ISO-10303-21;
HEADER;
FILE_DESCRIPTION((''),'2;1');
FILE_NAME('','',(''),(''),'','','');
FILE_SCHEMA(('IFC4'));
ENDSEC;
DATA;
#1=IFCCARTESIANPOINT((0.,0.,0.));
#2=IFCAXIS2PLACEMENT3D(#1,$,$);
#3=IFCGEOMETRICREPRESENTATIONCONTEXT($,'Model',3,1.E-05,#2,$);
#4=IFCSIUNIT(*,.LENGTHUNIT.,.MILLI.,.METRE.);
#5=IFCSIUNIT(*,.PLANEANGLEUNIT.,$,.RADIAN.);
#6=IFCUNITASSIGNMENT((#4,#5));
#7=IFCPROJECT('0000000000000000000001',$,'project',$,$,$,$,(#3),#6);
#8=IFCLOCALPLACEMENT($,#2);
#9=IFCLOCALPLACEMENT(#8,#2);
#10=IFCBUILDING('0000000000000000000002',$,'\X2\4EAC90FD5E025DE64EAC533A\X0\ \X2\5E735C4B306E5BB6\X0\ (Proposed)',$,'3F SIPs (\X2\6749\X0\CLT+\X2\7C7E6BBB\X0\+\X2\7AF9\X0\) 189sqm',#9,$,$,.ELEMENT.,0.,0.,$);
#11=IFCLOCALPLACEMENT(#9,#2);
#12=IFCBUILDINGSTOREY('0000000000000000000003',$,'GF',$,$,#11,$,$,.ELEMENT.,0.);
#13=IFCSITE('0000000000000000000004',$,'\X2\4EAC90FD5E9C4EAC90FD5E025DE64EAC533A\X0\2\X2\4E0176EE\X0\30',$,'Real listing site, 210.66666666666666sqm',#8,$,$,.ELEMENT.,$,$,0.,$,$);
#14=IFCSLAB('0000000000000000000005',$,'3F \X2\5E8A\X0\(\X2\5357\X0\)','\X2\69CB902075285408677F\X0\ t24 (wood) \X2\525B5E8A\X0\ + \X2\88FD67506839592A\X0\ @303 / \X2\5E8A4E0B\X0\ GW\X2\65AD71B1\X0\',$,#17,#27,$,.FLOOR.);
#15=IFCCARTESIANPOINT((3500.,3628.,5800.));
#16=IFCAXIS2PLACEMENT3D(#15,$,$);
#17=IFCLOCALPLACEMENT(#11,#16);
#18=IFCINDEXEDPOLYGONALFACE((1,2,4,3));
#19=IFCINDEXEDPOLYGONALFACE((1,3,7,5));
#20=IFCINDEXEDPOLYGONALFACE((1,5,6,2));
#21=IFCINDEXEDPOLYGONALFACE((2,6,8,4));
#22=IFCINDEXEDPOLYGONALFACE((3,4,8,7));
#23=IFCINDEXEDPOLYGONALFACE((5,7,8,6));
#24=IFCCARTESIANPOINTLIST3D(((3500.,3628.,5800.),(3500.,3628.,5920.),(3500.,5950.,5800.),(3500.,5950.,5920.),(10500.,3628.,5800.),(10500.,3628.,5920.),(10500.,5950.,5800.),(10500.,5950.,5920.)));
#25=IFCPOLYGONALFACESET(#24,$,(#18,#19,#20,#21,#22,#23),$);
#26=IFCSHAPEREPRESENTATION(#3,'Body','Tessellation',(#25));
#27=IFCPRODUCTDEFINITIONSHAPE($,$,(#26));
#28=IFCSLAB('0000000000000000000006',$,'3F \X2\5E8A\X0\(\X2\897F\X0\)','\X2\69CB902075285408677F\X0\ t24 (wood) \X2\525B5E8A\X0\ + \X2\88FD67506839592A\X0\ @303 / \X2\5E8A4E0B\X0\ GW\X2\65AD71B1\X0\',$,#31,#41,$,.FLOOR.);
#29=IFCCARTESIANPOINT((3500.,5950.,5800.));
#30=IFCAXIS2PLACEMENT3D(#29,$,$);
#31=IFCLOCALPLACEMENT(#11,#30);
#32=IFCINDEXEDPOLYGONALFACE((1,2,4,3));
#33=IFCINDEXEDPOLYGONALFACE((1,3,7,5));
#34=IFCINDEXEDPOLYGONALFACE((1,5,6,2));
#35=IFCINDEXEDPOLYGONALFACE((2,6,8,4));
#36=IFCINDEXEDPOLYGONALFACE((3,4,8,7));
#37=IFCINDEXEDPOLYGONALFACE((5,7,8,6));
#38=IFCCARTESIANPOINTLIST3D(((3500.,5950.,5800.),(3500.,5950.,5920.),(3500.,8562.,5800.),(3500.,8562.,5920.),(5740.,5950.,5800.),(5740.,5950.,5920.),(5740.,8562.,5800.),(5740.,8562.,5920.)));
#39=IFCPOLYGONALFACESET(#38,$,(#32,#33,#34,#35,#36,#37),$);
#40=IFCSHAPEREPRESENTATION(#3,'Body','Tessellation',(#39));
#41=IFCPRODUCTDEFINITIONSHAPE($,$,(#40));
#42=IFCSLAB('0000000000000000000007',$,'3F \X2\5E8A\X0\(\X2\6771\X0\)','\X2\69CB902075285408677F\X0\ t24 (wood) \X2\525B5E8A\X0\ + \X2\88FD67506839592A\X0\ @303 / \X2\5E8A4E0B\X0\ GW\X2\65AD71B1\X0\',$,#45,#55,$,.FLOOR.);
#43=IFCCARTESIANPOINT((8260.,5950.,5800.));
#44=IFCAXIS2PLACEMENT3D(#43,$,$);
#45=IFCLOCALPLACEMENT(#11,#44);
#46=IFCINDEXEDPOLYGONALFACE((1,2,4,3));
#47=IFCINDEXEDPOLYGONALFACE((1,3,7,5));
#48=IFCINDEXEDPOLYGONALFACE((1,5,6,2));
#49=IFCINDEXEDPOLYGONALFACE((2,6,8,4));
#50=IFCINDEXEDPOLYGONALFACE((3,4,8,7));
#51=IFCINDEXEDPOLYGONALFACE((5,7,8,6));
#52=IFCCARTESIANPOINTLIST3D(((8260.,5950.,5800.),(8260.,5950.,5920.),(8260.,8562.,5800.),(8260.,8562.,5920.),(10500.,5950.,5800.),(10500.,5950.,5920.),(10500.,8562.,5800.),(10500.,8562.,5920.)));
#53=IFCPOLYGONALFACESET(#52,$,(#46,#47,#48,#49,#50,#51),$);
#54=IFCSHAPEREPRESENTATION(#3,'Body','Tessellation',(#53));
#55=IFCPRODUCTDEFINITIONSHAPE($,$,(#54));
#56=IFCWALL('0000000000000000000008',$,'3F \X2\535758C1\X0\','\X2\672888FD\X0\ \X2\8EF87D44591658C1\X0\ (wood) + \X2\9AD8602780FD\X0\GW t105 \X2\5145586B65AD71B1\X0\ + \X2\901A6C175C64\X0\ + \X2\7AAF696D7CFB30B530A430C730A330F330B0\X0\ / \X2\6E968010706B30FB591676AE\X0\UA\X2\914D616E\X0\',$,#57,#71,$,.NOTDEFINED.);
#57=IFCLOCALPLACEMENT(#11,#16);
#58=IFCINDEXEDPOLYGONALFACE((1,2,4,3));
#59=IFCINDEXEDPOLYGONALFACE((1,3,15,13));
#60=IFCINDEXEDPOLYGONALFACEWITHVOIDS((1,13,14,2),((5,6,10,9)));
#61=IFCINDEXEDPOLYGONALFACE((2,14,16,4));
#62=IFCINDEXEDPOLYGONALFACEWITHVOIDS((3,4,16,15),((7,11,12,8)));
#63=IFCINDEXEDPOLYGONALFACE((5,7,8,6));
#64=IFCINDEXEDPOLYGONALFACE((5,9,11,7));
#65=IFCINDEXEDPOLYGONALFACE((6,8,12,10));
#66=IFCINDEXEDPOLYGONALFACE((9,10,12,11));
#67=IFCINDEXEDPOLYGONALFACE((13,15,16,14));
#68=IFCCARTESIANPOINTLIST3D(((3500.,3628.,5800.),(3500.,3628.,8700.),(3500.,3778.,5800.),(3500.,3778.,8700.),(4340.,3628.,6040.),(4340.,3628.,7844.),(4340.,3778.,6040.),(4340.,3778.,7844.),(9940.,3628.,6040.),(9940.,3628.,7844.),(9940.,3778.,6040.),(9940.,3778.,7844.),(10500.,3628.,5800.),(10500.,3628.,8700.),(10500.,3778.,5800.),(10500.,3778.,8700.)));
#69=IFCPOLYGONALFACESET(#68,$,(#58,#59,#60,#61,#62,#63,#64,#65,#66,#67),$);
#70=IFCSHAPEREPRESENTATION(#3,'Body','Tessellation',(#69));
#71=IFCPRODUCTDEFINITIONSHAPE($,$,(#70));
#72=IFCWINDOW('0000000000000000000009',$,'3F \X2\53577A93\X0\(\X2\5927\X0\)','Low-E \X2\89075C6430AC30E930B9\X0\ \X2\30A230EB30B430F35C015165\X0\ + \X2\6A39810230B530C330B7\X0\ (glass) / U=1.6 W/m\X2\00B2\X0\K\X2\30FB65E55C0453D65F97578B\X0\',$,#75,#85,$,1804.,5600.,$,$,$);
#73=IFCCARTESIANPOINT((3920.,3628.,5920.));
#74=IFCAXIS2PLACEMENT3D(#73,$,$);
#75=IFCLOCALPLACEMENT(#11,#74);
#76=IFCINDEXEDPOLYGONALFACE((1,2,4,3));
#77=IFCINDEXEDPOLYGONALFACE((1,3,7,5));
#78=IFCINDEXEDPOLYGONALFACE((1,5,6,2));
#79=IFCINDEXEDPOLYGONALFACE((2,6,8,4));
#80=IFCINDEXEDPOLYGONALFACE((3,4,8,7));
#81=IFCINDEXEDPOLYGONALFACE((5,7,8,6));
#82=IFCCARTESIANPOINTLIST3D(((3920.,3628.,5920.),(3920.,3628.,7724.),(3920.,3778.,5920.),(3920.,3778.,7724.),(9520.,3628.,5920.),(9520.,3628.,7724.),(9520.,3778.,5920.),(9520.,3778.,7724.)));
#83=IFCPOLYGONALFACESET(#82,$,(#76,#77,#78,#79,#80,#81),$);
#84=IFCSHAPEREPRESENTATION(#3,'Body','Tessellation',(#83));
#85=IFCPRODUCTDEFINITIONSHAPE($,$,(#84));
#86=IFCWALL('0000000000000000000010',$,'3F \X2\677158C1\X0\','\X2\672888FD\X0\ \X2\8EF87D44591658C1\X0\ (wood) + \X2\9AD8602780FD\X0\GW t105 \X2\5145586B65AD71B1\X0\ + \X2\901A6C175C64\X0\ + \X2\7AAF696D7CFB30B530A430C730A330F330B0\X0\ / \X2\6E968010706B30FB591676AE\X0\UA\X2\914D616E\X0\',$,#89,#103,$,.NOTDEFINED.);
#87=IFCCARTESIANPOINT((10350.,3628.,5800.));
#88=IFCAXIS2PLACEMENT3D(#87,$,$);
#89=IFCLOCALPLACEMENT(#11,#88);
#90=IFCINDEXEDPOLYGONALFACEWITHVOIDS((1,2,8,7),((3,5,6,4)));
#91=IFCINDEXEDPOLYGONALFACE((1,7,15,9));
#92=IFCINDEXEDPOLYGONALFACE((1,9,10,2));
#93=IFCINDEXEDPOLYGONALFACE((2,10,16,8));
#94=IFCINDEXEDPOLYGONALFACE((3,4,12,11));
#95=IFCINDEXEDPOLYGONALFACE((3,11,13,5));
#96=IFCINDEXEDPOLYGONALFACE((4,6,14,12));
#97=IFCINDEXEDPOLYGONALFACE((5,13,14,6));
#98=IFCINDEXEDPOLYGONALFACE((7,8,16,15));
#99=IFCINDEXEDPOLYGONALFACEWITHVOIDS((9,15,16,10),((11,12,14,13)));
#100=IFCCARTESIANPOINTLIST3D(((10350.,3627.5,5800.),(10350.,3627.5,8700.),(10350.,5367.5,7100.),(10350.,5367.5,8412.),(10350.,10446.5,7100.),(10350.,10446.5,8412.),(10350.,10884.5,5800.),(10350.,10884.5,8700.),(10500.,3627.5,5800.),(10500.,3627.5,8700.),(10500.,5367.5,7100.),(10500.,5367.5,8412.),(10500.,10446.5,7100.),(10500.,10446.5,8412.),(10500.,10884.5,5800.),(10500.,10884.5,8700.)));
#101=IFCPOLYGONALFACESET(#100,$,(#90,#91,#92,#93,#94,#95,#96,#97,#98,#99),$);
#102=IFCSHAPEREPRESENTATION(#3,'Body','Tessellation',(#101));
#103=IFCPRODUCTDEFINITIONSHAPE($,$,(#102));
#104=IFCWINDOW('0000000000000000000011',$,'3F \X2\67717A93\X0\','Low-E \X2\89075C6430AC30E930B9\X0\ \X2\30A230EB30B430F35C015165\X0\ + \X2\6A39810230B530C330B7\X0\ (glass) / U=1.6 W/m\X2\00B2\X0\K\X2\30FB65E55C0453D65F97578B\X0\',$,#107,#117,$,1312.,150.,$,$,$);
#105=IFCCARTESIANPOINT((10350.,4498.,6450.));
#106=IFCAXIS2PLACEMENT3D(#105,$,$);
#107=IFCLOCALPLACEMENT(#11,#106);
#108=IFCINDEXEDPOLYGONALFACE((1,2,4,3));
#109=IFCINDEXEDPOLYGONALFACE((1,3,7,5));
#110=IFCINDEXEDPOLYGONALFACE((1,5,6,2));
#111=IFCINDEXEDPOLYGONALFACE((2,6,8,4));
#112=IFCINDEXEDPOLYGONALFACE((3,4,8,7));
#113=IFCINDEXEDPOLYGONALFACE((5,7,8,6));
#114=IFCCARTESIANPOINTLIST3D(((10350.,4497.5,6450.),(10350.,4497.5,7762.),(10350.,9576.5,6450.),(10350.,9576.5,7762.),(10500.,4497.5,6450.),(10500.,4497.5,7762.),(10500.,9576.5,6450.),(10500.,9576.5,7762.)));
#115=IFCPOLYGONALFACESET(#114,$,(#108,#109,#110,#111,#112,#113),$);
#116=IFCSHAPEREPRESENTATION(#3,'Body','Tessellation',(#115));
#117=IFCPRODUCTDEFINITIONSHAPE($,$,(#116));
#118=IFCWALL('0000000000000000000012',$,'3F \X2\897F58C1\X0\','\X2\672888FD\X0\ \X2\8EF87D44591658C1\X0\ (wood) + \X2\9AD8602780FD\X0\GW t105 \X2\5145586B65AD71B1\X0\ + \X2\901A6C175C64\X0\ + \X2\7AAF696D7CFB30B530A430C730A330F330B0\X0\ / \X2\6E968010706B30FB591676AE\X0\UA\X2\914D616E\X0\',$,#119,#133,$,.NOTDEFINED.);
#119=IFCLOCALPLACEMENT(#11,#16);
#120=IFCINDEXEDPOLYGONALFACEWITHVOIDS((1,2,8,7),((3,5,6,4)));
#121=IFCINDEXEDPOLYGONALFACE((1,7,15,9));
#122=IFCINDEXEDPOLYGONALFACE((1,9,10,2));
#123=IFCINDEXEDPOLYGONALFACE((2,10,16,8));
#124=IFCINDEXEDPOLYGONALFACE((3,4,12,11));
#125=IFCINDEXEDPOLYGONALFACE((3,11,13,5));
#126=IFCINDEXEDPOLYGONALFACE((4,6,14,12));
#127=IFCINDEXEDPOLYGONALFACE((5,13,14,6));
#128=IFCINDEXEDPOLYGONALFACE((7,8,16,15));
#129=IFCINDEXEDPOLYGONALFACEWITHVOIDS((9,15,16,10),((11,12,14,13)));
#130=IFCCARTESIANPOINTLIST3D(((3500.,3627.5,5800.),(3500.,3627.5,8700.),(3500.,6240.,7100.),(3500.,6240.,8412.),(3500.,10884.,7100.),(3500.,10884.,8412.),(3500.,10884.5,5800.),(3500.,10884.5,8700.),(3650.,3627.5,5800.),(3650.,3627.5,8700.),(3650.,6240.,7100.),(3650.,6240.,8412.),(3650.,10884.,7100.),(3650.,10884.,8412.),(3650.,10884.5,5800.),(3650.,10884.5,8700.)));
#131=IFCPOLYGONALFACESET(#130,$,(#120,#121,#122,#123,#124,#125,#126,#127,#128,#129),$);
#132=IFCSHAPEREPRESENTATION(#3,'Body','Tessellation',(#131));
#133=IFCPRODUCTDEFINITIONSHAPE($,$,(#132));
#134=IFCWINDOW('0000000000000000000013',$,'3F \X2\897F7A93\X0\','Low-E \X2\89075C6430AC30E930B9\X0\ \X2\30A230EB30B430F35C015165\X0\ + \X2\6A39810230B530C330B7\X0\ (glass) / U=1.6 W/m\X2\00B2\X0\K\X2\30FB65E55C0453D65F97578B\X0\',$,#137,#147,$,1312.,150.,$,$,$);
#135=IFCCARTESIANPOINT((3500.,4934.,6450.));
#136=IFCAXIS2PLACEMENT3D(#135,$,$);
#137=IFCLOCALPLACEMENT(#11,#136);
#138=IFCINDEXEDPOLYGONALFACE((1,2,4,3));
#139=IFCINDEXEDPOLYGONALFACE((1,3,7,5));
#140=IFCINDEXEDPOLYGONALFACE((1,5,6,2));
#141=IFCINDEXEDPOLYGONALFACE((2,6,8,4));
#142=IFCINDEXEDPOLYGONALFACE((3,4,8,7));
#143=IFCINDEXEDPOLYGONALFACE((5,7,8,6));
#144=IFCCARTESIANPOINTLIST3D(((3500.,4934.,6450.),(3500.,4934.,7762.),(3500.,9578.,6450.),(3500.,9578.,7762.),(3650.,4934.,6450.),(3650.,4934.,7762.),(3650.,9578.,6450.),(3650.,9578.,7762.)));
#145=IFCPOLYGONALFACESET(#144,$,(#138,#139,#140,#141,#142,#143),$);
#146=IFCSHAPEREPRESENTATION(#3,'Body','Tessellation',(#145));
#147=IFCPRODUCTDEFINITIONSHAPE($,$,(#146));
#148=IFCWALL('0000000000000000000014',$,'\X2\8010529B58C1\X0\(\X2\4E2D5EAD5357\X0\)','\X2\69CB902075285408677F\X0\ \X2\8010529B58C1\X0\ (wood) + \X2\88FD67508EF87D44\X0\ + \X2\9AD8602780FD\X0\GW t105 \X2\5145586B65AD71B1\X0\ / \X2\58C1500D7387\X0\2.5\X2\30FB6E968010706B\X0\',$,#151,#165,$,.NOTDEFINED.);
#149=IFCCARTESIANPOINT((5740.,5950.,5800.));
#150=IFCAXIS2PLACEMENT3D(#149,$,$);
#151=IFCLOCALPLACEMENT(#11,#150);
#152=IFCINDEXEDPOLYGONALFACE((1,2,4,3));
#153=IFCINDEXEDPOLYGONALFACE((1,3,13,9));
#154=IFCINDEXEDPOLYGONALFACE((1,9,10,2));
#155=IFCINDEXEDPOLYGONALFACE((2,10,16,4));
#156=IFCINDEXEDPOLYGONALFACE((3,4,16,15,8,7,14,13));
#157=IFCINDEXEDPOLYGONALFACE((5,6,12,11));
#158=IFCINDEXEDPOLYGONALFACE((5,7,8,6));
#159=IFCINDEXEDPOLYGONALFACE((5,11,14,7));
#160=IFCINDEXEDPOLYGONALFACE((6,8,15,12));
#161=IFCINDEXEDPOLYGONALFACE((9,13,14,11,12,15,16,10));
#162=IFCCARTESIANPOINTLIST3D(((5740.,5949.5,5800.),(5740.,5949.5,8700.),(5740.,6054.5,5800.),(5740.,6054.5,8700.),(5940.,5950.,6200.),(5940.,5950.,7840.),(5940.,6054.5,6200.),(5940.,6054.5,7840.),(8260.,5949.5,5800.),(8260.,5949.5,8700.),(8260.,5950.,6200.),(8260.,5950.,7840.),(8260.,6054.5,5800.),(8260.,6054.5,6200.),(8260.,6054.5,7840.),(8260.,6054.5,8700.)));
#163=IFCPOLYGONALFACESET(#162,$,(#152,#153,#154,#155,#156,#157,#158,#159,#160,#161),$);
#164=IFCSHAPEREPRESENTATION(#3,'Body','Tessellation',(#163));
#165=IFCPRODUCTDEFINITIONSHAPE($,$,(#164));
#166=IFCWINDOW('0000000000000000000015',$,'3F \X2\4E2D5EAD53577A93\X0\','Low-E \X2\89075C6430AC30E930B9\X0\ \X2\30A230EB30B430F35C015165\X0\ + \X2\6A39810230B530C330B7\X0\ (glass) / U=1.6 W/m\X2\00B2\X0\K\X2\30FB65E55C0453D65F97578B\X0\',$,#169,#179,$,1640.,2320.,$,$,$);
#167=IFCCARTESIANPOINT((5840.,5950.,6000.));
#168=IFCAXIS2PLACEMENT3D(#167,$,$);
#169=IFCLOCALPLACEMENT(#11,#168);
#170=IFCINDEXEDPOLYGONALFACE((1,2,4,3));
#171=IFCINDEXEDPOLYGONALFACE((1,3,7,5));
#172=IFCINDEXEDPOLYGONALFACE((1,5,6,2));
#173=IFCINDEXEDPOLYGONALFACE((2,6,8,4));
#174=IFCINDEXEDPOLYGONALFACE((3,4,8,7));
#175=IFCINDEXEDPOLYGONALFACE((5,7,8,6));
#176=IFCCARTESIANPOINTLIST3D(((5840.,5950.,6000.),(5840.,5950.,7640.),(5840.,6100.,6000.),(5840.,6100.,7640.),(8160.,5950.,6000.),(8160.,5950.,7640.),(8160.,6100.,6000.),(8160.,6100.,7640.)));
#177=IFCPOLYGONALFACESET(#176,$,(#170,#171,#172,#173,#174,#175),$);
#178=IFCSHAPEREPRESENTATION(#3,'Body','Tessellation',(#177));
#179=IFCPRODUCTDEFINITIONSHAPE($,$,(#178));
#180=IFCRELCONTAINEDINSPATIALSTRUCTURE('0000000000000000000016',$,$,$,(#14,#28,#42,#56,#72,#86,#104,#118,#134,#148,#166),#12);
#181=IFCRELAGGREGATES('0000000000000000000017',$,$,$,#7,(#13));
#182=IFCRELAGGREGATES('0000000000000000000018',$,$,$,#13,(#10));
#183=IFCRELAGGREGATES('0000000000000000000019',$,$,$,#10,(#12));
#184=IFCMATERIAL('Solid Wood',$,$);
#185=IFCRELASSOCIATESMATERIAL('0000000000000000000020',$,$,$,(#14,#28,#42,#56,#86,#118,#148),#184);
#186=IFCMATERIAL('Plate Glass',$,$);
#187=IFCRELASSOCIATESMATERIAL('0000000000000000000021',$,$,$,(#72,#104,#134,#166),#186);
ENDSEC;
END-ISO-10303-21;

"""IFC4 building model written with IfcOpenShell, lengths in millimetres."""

from ifc_helpers import new_model, si_unit, frame, frame_2d, origin, place, context, project, spatial, rectangle, extrude, material, element, fill, save


model = new_model("IFC4")

# Units and contexts
model_context = context("Model", 3, precision=1e-05, world=origin())
ifc_project = project(units=[si_unit("LENGTHUNIT", "METRE", prefix="MILLI"), si_unit("PLANEANGLEUNIT", "RADIAN")], contexts=[model_context])

# Site, building, storey
site_placement = place(None, origin())
site = spatial("IfcSite", under=ifc_project, at=site_placement, Name="京都府京都市左京区2丁目30", ObjectType="Real listing site, 210.66666666666666sqm", CompositionType="ELEMENT", RefElevation=0.0)
building_placement = place(site_placement, origin())
building = spatial("IfcBuilding", under=site, at=building_placement, Name="京都市左京区 平屋の家 (Proposed)", ObjectType="3F SIPs (杉CLT+籾殻+竹) 189sqm", CompositionType="ELEMENT", ElevationOfRefHeight=0.0, ElevationOfTerrain=0.0)
storey_placement = place(building_placement, origin())
storey = spatial("IfcBuildingStorey", under=building, at=storey_placement, Name="GF", CompositionType="ELEMENT", Elevation=0.0)

# Slabs
ifc_material_1 = material(Name="Solid Wood")
slab_1_placement = place(storey_placement, frame((3500.0, 3628.0, 5800.0)))
element("IfcSlab", 1, at=slab_1_placement, inside=storey, material=ifc_material_1, Name="3F 床(南)", Description="構造用合板 t24 (wood) 剛床 + 製材根太 @303 / 床下 GW断熱", PredefinedType="FLOOR", context=model_context, shape_type="SweptSolid", body=[
    extrude(rectangle(XDim=7000.0, YDim=2322.0, at=frame_2d((3500.0, 1161.0))), frame((3500.0, 3628.0, 5800.0)), (0.0, 0.0, 1.0), 120.0),
])
slab_2_placement = place(storey_placement, frame((3500.0, 5950.0, 5800.0)))
element("IfcSlab", 2, at=slab_2_placement, inside=storey, material=ifc_material_1, Name="3F 床(西)", Description="構造用合板 t24 (wood) 剛床 + 製材根太 @303 / 床下 GW断熱", PredefinedType="FLOOR", context=model_context, shape_type="SweptSolid", body=[
    extrude(rectangle(XDim=2240.0, YDim=2612.0, at=frame_2d((1120.0, 1306.0))), frame((3500.0, 5950.0, 5800.0)), (0.0, 0.0, 1.0), 120.0),
])
slab_3_placement = place(storey_placement, frame((8260.0, 5950.0, 5800.0)))
element("IfcSlab", 3, at=slab_3_placement, inside=storey, material=ifc_material_1, Name="3F 床(東)", Description="構造用合板 t24 (wood) 剛床 + 製材根太 @303 / 床下 GW断熱", PredefinedType="FLOOR", context=model_context, shape_type="SweptSolid", body=[
    extrude(rectangle(XDim=2240.0, YDim=2612.0, at=frame_2d((1120.0, 1306.0))), frame((8260.0, 5950.0, 5800.0)), (0.0, 0.0, 1.0), 120.0),
])

# Walls, openings, windows
wall_1_placement = place(storey_placement, frame((3500.0, 3628.0, 5800.0)))
wall_1 = element("IfcWall", 4, at=wall_1_placement, inside=storey, material=ifc_material_1, Name="3F 南壁", Description="木製 軸組外壁 (wood) + 高性能GW t105 充填断熱 + 通気層 + 窯業系サイディング / 準耐火・外皮UA配慮", PredefinedType="NOTDEFINED", context=model_context, shape_type="SweptSolid", body=[
    extrude(rectangle(XDim=7000.0, YDim=150.0, at=frame_2d((3500.0, 75.0))), frame((3500.0, 3628.0, 5800.0)), (0.0, 0.0, 1.0), 2900.0),
])
opening_1_placement = place(storey_placement, frame((3920.0, 3628.0, 5920.0)))
opening_1 = element("IfcOpeningElement", 5, at=opening_1_placement, cuts=wall_1, PredefinedType="NOTDEFINED", context=model_context, shape_type="SweptSolid", body=[
    extrude(rectangle(XDim=5600.0, YDim=150.0, at=frame_2d((2800.0, 75.0))), frame((3920.0, 3628.0, 5920.0)), (0.0, 0.0, 1.0), 1804.0),
])
ifc_material_2 = material(Name="Plate Glass")
window_1_placement = place(storey_placement, frame((3920.0, 3628.0, 5920.0)))
window_1 = element("IfcWindow", 6, at=window_1_placement, inside=storey, material=ifc_material_2, Name="3F 南窓(大)", Description="Low-E 複層ガラス アルゴン封入 + 樹脂サッシ (glass) / U=1.6 W/m²K・日射取得型", OverallHeight=1804.0, OverallWidth=5600.0, context=model_context, shape_type="SweptSolid", body=[
    extrude(rectangle(XDim=5600.0, YDim=150.0, at=frame_2d((2800.0, 75.0))), frame((3920.0, 3628.0, 5920.0)), (0.0, 0.0, 1.0), 1804.0),
])
fill(opening_1, window_1)
wall_2_placement = place(storey_placement, frame((10350.0, 3628.0, 5800.0)))
wall_2 = element("IfcWall", 7, at=wall_2_placement, inside=storey, material=ifc_material_1, Name="3F 東壁", Description="木製 軸組外壁 (wood) + 高性能GW t105 充填断熱 + 通気層 + 窯業系サイディング / 準耐火・外皮UA配慮", PredefinedType="NOTDEFINED", context=model_context, shape_type="SweptSolid", body=[
    extrude(rectangle(XDim=150.0, YDim=7257.0, at=frame_2d((75.0, 3628.0))), frame((10350.0, 3628.0, 5800.0)), (0.0, 0.0, 1.0), 2900.0),
])
opening_2_placement = place(storey_placement, frame((10350.0, 4498.0, 6450.0)))
opening_2 = element("IfcOpeningElement", 8, at=opening_2_placement, cuts=wall_2, PredefinedType="NOTDEFINED", context=model_context, shape_type="SweptSolid", body=[
    extrude(rectangle(XDim=150.0, YDim=5079.0, at=frame_2d((75.0, 2539.0))), frame((10350.0, 4498.0, 6450.0)), (0.0, 0.0, 1.0), 1312.0),
])
window_2_placement = place(storey_placement, frame((10350.0, 4498.0, 6450.0)))
window_2 = element("IfcWindow", 9, at=window_2_placement, inside=storey, material=ifc_material_2, Name="3F 東窓", Description="Low-E 複層ガラス アルゴン封入 + 樹脂サッシ (glass) / U=1.6 W/m²K・日射取得型", OverallHeight=1312.0, OverallWidth=150.0, context=model_context, shape_type="SweptSolid", body=[
    extrude(rectangle(XDim=150.0, YDim=5079.0, at=frame_2d((75.0, 2539.0))), frame((10350.0, 4498.0, 6450.0)), (0.0, 0.0, 1.0), 1312.0),
])
fill(opening_2, window_2)
wall_3_placement = place(storey_placement, frame((3500.0, 3628.0, 5800.0)))
wall_3 = element("IfcWall", 10, at=wall_3_placement, inside=storey, material=ifc_material_1, Name="3F 西壁", Description="木製 軸組外壁 (wood) + 高性能GW t105 充填断熱 + 通気層 + 窯業系サイディング / 準耐火・外皮UA配慮", PredefinedType="NOTDEFINED", context=model_context, shape_type="SweptSolid", body=[
    extrude(rectangle(XDim=150.0, YDim=7257.0, at=frame_2d((75.0, 3628.0))), frame((3500.0, 3628.0, 5800.0)), (0.0, 0.0, 1.0), 2900.0),
])
opening_3_placement = place(storey_placement, frame((3500.0, 4934.0, 6450.0)))
opening_3 = element("IfcOpeningElement", 11, at=opening_3_placement, cuts=wall_3, PredefinedType="NOTDEFINED", context=model_context, shape_type="SweptSolid", body=[
    extrude(rectangle(XDim=150.0, YDim=4644.0, at=frame_2d((75.0, 2322.0))), frame((3500.0, 4934.0, 6450.0)), (0.0, 0.0, 1.0), 1312.0),
])
window_3_placement = place(storey_placement, frame((3500.0, 4934.0, 6450.0)))
window_3 = element("IfcWindow", 12, at=window_3_placement, inside=storey, material=ifc_material_2, Name="3F 西窓", Description="Low-E 複層ガラス アルゴン封入 + 樹脂サッシ (glass) / U=1.6 W/m²K・日射取得型", OverallHeight=1312.0, OverallWidth=150.0, context=model_context, shape_type="SweptSolid", body=[
    extrude(rectangle(XDim=150.0, YDim=4644.0, at=frame_2d((75.0, 2322.0))), frame((3500.0, 4934.0, 6450.0)), (0.0, 0.0, 1.0), 1312.0),
])
fill(opening_3, window_3)
wall_4_placement = place(storey_placement, frame((5740.0, 5950.0, 5800.0)))
wall_4 = element("IfcWall", 13, at=wall_4_placement, inside=storey, material=ifc_material_1, Name="耐力壁(中庭南)", Description="構造用合板 耐力壁 (wood) + 製材軸組 + 高性能GW t105 充填断熱 / 壁倍率2.5・準耐火", PredefinedType="NOTDEFINED", context=model_context, shape_type="SweptSolid", body=[
    extrude(rectangle(XDim=2520.0, YDim=105.0, at=frame_2d((1260.0, 52.0))), frame((5740.0, 5950.0, 5800.0)), (0.0, 0.0, 1.0), 2900.0),
])
opening_4_placement = place(storey_placement, frame((5840.0, 5950.0, 6000.0)))
opening_4 = element("IfcOpeningElement", 14, at=opening_4_placement, cuts=wall_4, PredefinedType="NOTDEFINED", context=model_context, shape_type="SweptSolid", body=[
    extrude(rectangle(XDim=2320.0, YDim=150.0, at=frame_2d((1160.0, 75.0))), frame((5840.0, 5950.0, 6000.0)), (0.0, 0.0, 1.0), 1640.0),
])
window_4_placement = place(storey_placement, frame((5840.0, 5950.0, 6000.0)))
window_4 = element("IfcWindow", 15, at=window_4_placement, inside=storey, material=ifc_material_2, Name="3F 中庭南窓", Description="Low-E 複層ガラス アルゴン封入 + 樹脂サッシ (glass) / U=1.6 W/m²K・日射取得型", OverallHeight=1640.0, OverallWidth=2320.0, context=model_context, shape_type="SweptSolid", body=[
    extrude(rectangle(XDim=2320.0, YDim=150.0, at=frame_2d((1160.0, 75.0))), frame((5840.0, 5950.0, 6000.0)), (0.0, 0.0, 1.0), 1640.0),
])
fill(opening_4, window_4)

save(model, "model.ifc")
